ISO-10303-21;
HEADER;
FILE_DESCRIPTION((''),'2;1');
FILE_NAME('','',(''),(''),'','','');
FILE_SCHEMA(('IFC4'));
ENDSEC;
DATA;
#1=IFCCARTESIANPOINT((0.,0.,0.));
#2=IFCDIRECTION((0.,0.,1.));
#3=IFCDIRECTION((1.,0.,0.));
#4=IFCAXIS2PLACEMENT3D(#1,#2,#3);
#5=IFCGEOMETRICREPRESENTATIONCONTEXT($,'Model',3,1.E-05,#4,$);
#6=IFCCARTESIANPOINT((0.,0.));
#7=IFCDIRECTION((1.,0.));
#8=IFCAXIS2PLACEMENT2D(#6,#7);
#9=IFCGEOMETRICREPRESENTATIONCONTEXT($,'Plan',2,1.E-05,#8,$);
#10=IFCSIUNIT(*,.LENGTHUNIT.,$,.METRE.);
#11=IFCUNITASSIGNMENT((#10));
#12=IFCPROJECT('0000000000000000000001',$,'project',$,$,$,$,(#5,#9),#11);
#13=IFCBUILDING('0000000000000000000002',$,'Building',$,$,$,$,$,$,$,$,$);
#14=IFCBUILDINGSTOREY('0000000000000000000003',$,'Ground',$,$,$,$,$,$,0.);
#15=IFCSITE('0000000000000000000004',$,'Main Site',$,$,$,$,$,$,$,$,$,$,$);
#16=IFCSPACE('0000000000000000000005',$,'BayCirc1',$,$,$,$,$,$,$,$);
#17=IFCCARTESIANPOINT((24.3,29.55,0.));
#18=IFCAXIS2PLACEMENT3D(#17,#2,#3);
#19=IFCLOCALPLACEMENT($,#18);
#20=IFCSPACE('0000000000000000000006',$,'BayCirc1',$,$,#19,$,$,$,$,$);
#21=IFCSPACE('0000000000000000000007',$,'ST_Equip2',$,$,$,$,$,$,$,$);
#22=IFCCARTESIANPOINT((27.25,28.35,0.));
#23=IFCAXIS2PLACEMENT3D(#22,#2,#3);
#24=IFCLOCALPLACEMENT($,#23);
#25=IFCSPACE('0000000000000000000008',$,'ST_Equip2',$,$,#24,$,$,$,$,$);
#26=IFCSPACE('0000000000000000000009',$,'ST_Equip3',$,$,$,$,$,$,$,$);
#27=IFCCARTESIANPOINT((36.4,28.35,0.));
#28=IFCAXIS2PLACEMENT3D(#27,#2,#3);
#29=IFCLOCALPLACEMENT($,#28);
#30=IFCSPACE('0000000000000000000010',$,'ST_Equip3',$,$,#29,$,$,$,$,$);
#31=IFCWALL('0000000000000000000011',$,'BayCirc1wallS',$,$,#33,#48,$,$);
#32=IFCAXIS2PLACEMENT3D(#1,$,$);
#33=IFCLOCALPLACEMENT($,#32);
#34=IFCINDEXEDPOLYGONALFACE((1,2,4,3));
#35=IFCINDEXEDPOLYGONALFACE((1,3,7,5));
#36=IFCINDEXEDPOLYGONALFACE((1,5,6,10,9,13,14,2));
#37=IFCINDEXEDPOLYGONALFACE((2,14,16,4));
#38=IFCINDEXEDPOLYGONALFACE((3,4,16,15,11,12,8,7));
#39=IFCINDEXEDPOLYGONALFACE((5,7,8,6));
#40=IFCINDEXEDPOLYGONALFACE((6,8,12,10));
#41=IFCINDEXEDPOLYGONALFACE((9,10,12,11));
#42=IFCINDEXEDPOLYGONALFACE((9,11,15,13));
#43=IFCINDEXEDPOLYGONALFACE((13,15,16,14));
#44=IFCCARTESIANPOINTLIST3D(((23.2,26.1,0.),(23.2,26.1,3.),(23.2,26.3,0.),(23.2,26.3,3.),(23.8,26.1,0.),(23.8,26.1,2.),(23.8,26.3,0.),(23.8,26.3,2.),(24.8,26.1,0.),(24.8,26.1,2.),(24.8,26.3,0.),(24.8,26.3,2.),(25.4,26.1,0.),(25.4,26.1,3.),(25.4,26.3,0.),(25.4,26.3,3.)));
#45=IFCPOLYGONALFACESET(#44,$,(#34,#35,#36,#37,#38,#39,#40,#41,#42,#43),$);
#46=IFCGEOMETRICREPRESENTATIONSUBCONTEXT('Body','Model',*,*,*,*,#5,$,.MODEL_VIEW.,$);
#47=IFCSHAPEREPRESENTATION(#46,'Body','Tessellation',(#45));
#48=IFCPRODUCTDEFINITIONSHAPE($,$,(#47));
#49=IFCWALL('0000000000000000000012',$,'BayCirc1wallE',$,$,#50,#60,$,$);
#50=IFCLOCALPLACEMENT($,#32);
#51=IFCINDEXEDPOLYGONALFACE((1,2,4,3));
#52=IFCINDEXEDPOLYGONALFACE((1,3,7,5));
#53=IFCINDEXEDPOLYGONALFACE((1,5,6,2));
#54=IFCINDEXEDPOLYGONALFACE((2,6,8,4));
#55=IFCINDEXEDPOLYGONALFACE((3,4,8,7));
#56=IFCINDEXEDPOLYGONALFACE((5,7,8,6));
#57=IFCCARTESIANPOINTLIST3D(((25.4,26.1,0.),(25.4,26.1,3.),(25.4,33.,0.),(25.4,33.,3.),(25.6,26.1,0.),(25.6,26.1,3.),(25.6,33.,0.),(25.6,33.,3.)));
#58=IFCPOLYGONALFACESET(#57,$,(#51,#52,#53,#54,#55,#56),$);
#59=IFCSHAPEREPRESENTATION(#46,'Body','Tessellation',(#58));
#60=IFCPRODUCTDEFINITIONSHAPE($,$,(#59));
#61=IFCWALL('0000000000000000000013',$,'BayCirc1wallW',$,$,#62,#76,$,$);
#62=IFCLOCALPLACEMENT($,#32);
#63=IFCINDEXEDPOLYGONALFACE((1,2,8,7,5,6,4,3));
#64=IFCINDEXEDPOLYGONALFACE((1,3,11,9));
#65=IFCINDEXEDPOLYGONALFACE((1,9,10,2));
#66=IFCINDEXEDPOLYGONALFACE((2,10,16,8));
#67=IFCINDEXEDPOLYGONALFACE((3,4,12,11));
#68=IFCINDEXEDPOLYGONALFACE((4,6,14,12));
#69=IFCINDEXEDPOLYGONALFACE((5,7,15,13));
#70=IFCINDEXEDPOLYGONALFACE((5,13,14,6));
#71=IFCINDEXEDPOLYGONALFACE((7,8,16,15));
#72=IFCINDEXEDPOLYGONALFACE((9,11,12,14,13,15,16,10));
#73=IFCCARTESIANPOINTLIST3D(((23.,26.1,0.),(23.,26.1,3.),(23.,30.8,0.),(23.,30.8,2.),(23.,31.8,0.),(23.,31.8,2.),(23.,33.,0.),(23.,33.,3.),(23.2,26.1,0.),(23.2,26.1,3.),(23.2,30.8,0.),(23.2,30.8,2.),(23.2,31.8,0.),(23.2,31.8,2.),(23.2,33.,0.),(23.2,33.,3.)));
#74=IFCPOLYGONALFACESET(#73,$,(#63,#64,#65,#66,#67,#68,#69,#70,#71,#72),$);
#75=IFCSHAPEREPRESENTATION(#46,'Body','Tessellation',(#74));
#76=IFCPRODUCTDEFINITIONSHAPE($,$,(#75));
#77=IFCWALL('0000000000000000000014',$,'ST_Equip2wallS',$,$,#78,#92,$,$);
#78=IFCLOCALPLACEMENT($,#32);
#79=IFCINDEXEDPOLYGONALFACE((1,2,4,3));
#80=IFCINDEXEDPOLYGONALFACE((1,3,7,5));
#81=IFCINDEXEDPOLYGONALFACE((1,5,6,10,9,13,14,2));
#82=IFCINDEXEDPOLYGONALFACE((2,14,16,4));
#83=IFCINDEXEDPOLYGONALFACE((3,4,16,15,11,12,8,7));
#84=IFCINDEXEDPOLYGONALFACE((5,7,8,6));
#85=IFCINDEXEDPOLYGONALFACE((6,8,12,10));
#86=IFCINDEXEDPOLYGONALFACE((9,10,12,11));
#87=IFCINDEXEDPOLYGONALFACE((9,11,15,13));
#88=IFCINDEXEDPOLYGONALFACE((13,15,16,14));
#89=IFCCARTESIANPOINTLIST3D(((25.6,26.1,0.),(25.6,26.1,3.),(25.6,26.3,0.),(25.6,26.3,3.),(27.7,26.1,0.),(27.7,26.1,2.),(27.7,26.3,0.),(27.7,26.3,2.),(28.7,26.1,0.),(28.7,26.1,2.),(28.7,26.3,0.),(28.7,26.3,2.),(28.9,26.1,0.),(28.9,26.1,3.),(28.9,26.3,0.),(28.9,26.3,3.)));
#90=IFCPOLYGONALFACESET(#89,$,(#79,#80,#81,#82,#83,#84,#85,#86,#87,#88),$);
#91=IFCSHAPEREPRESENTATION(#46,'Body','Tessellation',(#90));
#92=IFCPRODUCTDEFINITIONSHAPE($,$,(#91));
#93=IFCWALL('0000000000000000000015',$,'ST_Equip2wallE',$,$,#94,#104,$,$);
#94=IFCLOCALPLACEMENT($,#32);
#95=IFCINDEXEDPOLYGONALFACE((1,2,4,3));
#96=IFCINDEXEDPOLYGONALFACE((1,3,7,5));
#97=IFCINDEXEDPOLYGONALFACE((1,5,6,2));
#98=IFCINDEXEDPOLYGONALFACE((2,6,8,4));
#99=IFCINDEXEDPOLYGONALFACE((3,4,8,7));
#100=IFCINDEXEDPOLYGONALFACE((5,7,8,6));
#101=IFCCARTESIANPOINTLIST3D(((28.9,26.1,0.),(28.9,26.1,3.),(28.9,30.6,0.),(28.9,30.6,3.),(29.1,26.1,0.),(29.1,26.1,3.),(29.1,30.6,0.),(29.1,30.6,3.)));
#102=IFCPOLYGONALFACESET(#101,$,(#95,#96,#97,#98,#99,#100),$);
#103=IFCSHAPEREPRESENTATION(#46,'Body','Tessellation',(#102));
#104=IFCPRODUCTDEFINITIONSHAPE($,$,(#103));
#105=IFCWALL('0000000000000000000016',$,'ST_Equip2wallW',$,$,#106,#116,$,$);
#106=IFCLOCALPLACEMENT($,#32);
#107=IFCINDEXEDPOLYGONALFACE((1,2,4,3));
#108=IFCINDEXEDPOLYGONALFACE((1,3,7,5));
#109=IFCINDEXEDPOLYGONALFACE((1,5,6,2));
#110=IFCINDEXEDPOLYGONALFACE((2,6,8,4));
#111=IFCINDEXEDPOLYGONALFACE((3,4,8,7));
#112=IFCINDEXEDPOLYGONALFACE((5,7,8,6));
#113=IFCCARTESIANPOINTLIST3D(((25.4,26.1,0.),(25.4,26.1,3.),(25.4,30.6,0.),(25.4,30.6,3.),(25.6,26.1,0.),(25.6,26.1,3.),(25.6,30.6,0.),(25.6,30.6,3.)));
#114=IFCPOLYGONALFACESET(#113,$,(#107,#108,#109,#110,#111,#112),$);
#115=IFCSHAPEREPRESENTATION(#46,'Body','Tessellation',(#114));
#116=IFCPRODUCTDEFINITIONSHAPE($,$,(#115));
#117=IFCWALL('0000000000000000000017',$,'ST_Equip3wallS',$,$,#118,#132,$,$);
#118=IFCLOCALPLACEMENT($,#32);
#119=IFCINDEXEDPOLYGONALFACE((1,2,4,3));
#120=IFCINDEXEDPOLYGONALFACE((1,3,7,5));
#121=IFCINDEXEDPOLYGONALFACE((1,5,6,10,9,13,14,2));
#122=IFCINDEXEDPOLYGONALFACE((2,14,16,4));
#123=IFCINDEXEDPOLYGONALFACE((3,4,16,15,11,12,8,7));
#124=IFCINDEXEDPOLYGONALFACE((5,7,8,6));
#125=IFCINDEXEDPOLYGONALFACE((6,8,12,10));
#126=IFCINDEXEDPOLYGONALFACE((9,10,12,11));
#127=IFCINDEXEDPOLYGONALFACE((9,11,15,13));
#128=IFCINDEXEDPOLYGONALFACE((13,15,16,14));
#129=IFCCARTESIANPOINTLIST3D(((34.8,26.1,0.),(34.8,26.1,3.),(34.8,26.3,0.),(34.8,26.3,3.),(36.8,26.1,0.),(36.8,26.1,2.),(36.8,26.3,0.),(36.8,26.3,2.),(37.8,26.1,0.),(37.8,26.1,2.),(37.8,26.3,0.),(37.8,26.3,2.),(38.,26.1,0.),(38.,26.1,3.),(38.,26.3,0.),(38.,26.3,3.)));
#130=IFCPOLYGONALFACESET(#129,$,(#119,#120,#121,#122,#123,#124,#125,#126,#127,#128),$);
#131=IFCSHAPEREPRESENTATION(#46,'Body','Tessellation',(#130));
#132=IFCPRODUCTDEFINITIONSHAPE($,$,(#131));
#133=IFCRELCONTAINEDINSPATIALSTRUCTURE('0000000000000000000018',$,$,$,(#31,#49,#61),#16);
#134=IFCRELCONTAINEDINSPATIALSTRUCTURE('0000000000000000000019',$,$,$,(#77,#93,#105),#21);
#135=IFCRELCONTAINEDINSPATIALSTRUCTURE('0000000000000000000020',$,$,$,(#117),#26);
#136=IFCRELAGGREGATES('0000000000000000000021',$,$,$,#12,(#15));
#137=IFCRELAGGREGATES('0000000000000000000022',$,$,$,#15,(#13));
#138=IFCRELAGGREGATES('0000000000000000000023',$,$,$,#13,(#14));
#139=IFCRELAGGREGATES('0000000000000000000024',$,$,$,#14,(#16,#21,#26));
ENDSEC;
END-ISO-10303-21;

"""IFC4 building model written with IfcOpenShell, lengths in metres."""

from ifc_helpers import new_model, si_unit, frame, origin_with_axes, origin_2d_with_axis, place, context, subcontext, project, spatial, indexed_curve, outline, extrude, element, save


model = new_model("IFC4")

# Units and contexts
model_context = context("Model", 3, precision=1e-05, world=origin_with_axes())
plan_context = context("Plan", 2, precision=1e-05, world=origin_2d_with_axis())
body_context = subcontext(model_context, "Body", "Model", "MODEL_VIEW")
ifc_project = project(units=[si_unit("LENGTHUNIT", "METRE")], contexts=[model_context, plan_context])

# Site, building, storey
site = spatial("IfcSite", under=ifc_project, Name="Main Site")
building = spatial("IfcBuilding", under=site, Name="Building")
storey = spatial("IfcBuildingStorey", under=building, Name="Ground", Elevation=0.0)

# Shared definitions
space_1 = spatial("IfcSpace", under=storey, Name="BayCirc1")

# Wall
wall_1_placement = place(None, frame((23.2, 26.1, 0.0), z_axis=(0.0, 0.0, 1.0), x_axis=(1.0, 0.0, 0.0)))
wall_1 = element("IfcWall", 1, at=wall_1_placement, inside=space_1, Name="BayCirc1wallS", context=body_context, shape_type="SweptSolid", body=[
    extrude(outline(indexed_curve([(0.0, 0.0), (0.0, 0.2), (2.2, 0.2), (2.2, 0.0), (0.0, 0.0)], self_intersect=False)), origin_with_axes(), (0.0, 0.0, 1.0), 3.0),
])

# Shared definitions
space_2_placement = place(None, frame((24.3, 29.55, 0.0), z_axis=(0.0, 0.0, 1.0), x_axis=(1.0, 0.0, 0.0)))
space_2 = spatial("IfcSpace", at=space_2_placement, Name="BayCirc1")

# Opening
opening_1_placement = place(wall_1_placement, frame((0.6, 0.0, 0.0), z_axis=(0.0, 0.0, 1.0), x_axis=(1.0, 0.0, 0.0)))
element("IfcOpeningElement", 2, at=opening_1_placement, inside=space_2, cuts=wall_1, context=body_context, shape_type="SweptSolid", body=[
    extrude(outline(indexed_curve([(0.0, 0.0), (0.0, 0.4), (1.0, 0.4), (1.0, 0.0), (0.0, 0.0)], self_intersect=False)), origin_with_axes(), (0.0, 0.0, 1.0), 2.0),
])

# Wall
wall_2_placement = place(None, frame((25.6, 26.1, 0.0), z_axis=(0.0, 0.0, 1.0), x_axis=(0.0, 1.0, 0.0)))
element("IfcWall", 3, at=wall_2_placement, inside=space_1, Name="BayCirc1wallE", context=body_context, shape_type="SweptSolid", body=[
    extrude(outline(indexed_curve([(0.0, 0.0), (0.0, 0.2), (6.9, 0.2), (6.9, 0.0), (0.0, 0.0)], self_intersect=False)), origin_with_axes(), (0.0, 0.0, 1.0), 3.0),
])

# Wall, opening
wall_3_placement = place(None, frame((23.2, 26.1, 0.0), z_axis=(0.0, 0.0, 1.0), x_axis=(0.0, 1.0, 0.0)))
wall_3 = element("IfcWall", 4, at=wall_3_placement, inside=space_1, Name="BayCirc1wallW", context=body_context, shape_type="SweptSolid", body=[
    extrude(outline(indexed_curve([(0.0, 0.0), (0.0, 0.2), (6.9, 0.2), (6.9, 0.0), (0.0, 0.0)], self_intersect=False)), origin_with_axes(), (0.0, 0.0, 1.0), 3.0),
])
opening_2_placement = place(wall_3_placement, frame((4.7, 0.0, 0.0), z_axis=(0.0, 0.0, 1.0), x_axis=(1.0, 0.0, 0.0)))
element("IfcOpeningElement", 5, at=opening_2_placement, inside=space_2, cuts=wall_3, context=body_context, shape_type="SweptSolid", body=[
    extrude(outline(indexed_curve([(0.0, 0.0), (0.0, 0.4), (1.0, 0.4), (1.0, 0.0), (0.0, 0.0)], self_intersect=False)), origin_with_axes(), (0.0, 0.0, 1.0), 2.0),
])

# Shared definitions
space_3 = spatial("IfcSpace", under=storey, Name="ST_Equip2")

# Wall
wall_4_placement = place(None, frame((25.6, 26.1, 0.0), z_axis=(0.0, 0.0, 1.0), x_axis=(1.0, 0.0, 0.0)))
wall_4 = element("IfcWall", 6, at=wall_4_placement, inside=space_3, Name="ST_Equip2wallS", context=body_context, shape_type="SweptSolid", body=[
    extrude(outline(indexed_curve([(0.0, 0.0), (0.0, 0.2), (3.3, 0.2), (3.3, 0.0), (0.0, 0.0)], self_intersect=False)), origin_with_axes(), (0.0, 0.0, 1.0), 3.0),
])

# Shared definitions
space_4_placement = place(None, frame((27.25, 28.35, 0.0), z_axis=(0.0, 0.0, 1.0), x_axis=(1.0, 0.0, 0.0)))
space_4 = spatial("IfcSpace", at=space_4_placement, Name="ST_Equip2")

# Opening
opening_3_placement = place(wall_4_placement, frame((2.1, 0.0, 0.0), z_axis=(0.0, 0.0, 1.0), x_axis=(1.0, 0.0, 0.0)))
element("IfcOpeningElement", 7, at=opening_3_placement, inside=space_4, cuts=wall_4, context=body_context, shape_type="SweptSolid", body=[
    extrude(outline(indexed_curve([(0.0, 0.0), (0.0, 0.4), (1.0, 0.4), (1.0, 0.0), (0.0, 0.0)], self_intersect=False)), origin_with_axes(), (0.0, 0.0, 1.0), 2.0),
])

# Walls
for number, where, z_axis, x_axis, name in (
    (8, (29.1, 26.1, 0.0), (0.0, 0.0, 1.0), (0.0, 1.0, 0.0), "ST_Equip2wallE"),
    (9, (25.6, 26.1, 0.0), (0.0, 0.0, 1.0), (0.0, 1.0, 0.0), "ST_Equip2wallW"),
):
    element("IfcWall", number, at=place(None, frame(where, z_axis=z_axis, x_axis=x_axis)), inside=space_3, Name=name, context=body_context, shape_type="SweptSolid", body=[
        extrude(outline(indexed_curve([(0.0, 0.0), (0.0, 0.2), (4.5, 0.2), (4.5, 0.0), (0.0, 0.0)], self_intersect=False)), origin_with_axes(), (0.0, 0.0, 1.0), 3.0),
    ])

# Shared definitions
space_5 = spatial("IfcSpace", under=storey, Name="ST_Equip3")

# Wall
wall_5_placement = place(None, frame((34.8, 26.1, 0.0), z_axis=(0.0, 0.0, 1.0), x_axis=(1.0, 0.0, 0.0)))
wall_5 = element("IfcWall", 10, at=wall_5_placement, inside=space_5, Name="ST_Equip3wallS", context=body_context, shape_type="SweptSolid", body=[
    extrude(outline(indexed_curve([(0.0, 0.0), (0.0, 0.2), (3.2, 0.2), (3.2, 0.0), (0.0, 0.0)], self_intersect=False)), origin_with_axes(), (0.0, 0.0, 1.0), 3.0),
])

# Shared definitions
space_6_placement = place(None, frame((36.4, 28.35, 0.0), z_axis=(0.0, 0.0, 1.0), x_axis=(1.0, 0.0, 0.0)))
space_6 = spatial("IfcSpace", at=space_6_placement, Name="ST_Equip3")

# Opening
opening_4_placement = place(wall_5_placement, frame((2.0, 0.0, 0.0), z_axis=(0.0, 0.0, 1.0), x_axis=(1.0, 0.0, 0.0)))
element("IfcOpeningElement", 11, at=opening_4_placement, inside=space_6, cuts=wall_5, context=body_context, shape_type="SweptSolid", body=[
    extrude(outline(indexed_curve([(0.0, 0.0), (0.0, 0.4), (1.0, 0.4), (1.0, 0.0), (0.0, 0.0)], self_intersect=False)), origin_with_axes(), (0.0, 0.0, 1.0), 2.0),
])

save(model, "model.ifc")
